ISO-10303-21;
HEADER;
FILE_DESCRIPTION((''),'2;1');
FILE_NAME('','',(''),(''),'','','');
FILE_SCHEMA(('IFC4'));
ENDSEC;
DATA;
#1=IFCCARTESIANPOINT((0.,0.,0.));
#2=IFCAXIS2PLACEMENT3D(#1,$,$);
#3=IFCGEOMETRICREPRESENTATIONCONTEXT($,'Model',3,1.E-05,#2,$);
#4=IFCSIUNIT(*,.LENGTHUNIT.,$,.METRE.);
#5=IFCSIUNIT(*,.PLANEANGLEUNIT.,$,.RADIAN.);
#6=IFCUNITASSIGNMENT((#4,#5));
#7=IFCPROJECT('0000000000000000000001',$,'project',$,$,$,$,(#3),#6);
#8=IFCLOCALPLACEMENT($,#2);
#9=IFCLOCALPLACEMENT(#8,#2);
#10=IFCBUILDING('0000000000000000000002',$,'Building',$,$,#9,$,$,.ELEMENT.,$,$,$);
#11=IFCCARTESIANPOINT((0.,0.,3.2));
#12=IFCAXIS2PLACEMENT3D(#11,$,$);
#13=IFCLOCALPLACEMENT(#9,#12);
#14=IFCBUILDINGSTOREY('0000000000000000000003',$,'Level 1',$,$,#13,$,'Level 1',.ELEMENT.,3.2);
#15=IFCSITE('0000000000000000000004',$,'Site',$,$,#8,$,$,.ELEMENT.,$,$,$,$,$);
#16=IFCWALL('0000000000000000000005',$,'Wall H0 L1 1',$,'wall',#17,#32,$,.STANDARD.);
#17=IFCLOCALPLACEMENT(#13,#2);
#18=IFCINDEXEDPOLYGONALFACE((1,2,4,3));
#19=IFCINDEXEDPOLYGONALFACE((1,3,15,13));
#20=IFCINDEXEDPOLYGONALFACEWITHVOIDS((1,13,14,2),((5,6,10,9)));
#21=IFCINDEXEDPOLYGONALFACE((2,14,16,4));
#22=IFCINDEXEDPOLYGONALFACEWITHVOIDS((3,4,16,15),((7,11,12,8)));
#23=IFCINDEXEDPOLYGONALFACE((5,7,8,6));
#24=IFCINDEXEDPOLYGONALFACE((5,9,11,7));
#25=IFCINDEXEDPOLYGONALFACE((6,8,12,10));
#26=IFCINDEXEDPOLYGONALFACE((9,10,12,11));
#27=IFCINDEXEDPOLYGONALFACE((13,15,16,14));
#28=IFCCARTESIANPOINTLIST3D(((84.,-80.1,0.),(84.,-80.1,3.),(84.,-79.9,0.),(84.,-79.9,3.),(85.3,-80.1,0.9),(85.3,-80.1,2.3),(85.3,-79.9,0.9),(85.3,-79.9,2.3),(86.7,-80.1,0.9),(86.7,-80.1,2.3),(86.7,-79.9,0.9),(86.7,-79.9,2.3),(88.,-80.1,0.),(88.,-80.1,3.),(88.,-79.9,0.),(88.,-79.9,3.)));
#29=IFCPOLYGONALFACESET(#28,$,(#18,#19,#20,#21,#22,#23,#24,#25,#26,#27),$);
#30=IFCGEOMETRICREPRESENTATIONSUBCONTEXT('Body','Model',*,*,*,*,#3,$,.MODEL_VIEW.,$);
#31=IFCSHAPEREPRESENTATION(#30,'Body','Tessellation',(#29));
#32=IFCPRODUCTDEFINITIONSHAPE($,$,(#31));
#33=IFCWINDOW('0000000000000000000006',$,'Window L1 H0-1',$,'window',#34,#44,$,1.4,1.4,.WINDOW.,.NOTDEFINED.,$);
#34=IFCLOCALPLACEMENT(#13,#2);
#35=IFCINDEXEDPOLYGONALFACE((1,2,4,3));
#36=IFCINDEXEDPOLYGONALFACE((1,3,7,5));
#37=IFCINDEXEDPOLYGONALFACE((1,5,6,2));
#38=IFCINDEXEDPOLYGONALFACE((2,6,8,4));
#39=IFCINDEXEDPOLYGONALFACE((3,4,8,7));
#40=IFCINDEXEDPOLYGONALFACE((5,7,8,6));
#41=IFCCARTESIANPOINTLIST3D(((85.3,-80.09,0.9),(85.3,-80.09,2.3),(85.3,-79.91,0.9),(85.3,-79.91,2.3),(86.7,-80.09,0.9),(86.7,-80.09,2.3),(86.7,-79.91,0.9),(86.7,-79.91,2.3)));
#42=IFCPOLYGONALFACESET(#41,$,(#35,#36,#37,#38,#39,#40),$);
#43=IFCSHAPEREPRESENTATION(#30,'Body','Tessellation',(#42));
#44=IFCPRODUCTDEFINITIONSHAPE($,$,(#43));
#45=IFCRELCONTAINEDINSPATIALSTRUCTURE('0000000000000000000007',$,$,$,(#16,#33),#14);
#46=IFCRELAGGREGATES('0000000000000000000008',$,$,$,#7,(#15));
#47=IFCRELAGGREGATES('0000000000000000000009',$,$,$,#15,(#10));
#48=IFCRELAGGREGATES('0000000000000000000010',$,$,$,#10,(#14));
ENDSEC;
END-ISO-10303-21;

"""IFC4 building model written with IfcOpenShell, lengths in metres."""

from ifc_helpers import new_model, si_unit, frame, frame_2d, origin, origin_2d, place, context, subcontext, project, spatial, rectangle, extrude, element, fill, save


model = new_model("IFC4")

# Units and contexts
model_context = context("Model", 3, precision=1e-05, world=origin())
body_context = subcontext(model_context, "Body", "Model", "MODEL_VIEW")
ifc_project = project(units=[si_unit("LENGTHUNIT", "METRE"), si_unit("PLANEANGLEUNIT", "RADIAN")], contexts=[model_context])

# Site, building, storey
site_placement = place(None, origin())
site = spatial("IfcSite", under=ifc_project, at=site_placement, Name="Site", CompositionType="ELEMENT")
building_placement = place(site_placement, origin())
building = spatial("IfcBuilding", under=site, at=building_placement, Name="Building", CompositionType="ELEMENT")
storey_placement = place(building_placement, frame((0.0, 0.0, 3.2)))
storey = spatial("IfcBuildingStorey", under=building, at=storey_placement, Name="Level 1", LongName="Level 1", CompositionType="ELEMENT", Elevation=3.2)

# Wall, opening, window
wall_1_placement = place(storey_placement, frame((84.0, -80.0, 0.0), z_axis=(0.0, 0.0, 1.0), x_axis=(1.0, 0.0, 0.0)))
wall_1 = element("IfcWall", 1, at=wall_1_placement, inside=storey, Name="Wall H0 L1 1", ObjectType="wall", PredefinedType="STANDARD", context=body_context, shape_type="SweptSolid", body=[
    extrude(rectangle(XDim=4.0, YDim=0.2, at=frame_2d((2.0, 0.0))), origin(), (0.0, 0.0, 1.0), 3.0),
])
opening_placement = place(storey_placement, frame((86.0, -80.0, 0.9), z_axis=(0.0, 0.0, 1.0), x_axis=(1.0, 0.0, 0.0)))
opening = element("IfcOpeningElement", 2, at=opening_placement, cuts=wall_1, ObjectType="Opening", PredefinedType="OPENING", context=body_context, shape_type="SweptSolid", body=[
    extrude(rectangle(XDim=1.4, YDim=0.22, at=origin_2d()), origin(), (0.0, 0.0, 1.0), 1.4),
])
window_placement = place(storey_placement, frame((86.0, -80.0, 0.9), z_axis=(0.0, 0.0, 1.0), x_axis=(1.0, 0.0, 0.0)))
window = element("IfcWindow", 3, at=window_placement, inside=storey, Name="Window L1 H0-1", ObjectType="window", OverallHeight=1.4, OverallWidth=1.4, PartitioningType="NOTDEFINED", PredefinedType="WINDOW", context=body_context, shape_type="SweptSolid", body=[
    extrude(rectangle(XDim=1.4, YDim=0.18, at=origin_2d()), origin(), (0.0, 0.0, 1.0), 1.4),
])
fill(opening, window)

save(model, "model.ifc")
